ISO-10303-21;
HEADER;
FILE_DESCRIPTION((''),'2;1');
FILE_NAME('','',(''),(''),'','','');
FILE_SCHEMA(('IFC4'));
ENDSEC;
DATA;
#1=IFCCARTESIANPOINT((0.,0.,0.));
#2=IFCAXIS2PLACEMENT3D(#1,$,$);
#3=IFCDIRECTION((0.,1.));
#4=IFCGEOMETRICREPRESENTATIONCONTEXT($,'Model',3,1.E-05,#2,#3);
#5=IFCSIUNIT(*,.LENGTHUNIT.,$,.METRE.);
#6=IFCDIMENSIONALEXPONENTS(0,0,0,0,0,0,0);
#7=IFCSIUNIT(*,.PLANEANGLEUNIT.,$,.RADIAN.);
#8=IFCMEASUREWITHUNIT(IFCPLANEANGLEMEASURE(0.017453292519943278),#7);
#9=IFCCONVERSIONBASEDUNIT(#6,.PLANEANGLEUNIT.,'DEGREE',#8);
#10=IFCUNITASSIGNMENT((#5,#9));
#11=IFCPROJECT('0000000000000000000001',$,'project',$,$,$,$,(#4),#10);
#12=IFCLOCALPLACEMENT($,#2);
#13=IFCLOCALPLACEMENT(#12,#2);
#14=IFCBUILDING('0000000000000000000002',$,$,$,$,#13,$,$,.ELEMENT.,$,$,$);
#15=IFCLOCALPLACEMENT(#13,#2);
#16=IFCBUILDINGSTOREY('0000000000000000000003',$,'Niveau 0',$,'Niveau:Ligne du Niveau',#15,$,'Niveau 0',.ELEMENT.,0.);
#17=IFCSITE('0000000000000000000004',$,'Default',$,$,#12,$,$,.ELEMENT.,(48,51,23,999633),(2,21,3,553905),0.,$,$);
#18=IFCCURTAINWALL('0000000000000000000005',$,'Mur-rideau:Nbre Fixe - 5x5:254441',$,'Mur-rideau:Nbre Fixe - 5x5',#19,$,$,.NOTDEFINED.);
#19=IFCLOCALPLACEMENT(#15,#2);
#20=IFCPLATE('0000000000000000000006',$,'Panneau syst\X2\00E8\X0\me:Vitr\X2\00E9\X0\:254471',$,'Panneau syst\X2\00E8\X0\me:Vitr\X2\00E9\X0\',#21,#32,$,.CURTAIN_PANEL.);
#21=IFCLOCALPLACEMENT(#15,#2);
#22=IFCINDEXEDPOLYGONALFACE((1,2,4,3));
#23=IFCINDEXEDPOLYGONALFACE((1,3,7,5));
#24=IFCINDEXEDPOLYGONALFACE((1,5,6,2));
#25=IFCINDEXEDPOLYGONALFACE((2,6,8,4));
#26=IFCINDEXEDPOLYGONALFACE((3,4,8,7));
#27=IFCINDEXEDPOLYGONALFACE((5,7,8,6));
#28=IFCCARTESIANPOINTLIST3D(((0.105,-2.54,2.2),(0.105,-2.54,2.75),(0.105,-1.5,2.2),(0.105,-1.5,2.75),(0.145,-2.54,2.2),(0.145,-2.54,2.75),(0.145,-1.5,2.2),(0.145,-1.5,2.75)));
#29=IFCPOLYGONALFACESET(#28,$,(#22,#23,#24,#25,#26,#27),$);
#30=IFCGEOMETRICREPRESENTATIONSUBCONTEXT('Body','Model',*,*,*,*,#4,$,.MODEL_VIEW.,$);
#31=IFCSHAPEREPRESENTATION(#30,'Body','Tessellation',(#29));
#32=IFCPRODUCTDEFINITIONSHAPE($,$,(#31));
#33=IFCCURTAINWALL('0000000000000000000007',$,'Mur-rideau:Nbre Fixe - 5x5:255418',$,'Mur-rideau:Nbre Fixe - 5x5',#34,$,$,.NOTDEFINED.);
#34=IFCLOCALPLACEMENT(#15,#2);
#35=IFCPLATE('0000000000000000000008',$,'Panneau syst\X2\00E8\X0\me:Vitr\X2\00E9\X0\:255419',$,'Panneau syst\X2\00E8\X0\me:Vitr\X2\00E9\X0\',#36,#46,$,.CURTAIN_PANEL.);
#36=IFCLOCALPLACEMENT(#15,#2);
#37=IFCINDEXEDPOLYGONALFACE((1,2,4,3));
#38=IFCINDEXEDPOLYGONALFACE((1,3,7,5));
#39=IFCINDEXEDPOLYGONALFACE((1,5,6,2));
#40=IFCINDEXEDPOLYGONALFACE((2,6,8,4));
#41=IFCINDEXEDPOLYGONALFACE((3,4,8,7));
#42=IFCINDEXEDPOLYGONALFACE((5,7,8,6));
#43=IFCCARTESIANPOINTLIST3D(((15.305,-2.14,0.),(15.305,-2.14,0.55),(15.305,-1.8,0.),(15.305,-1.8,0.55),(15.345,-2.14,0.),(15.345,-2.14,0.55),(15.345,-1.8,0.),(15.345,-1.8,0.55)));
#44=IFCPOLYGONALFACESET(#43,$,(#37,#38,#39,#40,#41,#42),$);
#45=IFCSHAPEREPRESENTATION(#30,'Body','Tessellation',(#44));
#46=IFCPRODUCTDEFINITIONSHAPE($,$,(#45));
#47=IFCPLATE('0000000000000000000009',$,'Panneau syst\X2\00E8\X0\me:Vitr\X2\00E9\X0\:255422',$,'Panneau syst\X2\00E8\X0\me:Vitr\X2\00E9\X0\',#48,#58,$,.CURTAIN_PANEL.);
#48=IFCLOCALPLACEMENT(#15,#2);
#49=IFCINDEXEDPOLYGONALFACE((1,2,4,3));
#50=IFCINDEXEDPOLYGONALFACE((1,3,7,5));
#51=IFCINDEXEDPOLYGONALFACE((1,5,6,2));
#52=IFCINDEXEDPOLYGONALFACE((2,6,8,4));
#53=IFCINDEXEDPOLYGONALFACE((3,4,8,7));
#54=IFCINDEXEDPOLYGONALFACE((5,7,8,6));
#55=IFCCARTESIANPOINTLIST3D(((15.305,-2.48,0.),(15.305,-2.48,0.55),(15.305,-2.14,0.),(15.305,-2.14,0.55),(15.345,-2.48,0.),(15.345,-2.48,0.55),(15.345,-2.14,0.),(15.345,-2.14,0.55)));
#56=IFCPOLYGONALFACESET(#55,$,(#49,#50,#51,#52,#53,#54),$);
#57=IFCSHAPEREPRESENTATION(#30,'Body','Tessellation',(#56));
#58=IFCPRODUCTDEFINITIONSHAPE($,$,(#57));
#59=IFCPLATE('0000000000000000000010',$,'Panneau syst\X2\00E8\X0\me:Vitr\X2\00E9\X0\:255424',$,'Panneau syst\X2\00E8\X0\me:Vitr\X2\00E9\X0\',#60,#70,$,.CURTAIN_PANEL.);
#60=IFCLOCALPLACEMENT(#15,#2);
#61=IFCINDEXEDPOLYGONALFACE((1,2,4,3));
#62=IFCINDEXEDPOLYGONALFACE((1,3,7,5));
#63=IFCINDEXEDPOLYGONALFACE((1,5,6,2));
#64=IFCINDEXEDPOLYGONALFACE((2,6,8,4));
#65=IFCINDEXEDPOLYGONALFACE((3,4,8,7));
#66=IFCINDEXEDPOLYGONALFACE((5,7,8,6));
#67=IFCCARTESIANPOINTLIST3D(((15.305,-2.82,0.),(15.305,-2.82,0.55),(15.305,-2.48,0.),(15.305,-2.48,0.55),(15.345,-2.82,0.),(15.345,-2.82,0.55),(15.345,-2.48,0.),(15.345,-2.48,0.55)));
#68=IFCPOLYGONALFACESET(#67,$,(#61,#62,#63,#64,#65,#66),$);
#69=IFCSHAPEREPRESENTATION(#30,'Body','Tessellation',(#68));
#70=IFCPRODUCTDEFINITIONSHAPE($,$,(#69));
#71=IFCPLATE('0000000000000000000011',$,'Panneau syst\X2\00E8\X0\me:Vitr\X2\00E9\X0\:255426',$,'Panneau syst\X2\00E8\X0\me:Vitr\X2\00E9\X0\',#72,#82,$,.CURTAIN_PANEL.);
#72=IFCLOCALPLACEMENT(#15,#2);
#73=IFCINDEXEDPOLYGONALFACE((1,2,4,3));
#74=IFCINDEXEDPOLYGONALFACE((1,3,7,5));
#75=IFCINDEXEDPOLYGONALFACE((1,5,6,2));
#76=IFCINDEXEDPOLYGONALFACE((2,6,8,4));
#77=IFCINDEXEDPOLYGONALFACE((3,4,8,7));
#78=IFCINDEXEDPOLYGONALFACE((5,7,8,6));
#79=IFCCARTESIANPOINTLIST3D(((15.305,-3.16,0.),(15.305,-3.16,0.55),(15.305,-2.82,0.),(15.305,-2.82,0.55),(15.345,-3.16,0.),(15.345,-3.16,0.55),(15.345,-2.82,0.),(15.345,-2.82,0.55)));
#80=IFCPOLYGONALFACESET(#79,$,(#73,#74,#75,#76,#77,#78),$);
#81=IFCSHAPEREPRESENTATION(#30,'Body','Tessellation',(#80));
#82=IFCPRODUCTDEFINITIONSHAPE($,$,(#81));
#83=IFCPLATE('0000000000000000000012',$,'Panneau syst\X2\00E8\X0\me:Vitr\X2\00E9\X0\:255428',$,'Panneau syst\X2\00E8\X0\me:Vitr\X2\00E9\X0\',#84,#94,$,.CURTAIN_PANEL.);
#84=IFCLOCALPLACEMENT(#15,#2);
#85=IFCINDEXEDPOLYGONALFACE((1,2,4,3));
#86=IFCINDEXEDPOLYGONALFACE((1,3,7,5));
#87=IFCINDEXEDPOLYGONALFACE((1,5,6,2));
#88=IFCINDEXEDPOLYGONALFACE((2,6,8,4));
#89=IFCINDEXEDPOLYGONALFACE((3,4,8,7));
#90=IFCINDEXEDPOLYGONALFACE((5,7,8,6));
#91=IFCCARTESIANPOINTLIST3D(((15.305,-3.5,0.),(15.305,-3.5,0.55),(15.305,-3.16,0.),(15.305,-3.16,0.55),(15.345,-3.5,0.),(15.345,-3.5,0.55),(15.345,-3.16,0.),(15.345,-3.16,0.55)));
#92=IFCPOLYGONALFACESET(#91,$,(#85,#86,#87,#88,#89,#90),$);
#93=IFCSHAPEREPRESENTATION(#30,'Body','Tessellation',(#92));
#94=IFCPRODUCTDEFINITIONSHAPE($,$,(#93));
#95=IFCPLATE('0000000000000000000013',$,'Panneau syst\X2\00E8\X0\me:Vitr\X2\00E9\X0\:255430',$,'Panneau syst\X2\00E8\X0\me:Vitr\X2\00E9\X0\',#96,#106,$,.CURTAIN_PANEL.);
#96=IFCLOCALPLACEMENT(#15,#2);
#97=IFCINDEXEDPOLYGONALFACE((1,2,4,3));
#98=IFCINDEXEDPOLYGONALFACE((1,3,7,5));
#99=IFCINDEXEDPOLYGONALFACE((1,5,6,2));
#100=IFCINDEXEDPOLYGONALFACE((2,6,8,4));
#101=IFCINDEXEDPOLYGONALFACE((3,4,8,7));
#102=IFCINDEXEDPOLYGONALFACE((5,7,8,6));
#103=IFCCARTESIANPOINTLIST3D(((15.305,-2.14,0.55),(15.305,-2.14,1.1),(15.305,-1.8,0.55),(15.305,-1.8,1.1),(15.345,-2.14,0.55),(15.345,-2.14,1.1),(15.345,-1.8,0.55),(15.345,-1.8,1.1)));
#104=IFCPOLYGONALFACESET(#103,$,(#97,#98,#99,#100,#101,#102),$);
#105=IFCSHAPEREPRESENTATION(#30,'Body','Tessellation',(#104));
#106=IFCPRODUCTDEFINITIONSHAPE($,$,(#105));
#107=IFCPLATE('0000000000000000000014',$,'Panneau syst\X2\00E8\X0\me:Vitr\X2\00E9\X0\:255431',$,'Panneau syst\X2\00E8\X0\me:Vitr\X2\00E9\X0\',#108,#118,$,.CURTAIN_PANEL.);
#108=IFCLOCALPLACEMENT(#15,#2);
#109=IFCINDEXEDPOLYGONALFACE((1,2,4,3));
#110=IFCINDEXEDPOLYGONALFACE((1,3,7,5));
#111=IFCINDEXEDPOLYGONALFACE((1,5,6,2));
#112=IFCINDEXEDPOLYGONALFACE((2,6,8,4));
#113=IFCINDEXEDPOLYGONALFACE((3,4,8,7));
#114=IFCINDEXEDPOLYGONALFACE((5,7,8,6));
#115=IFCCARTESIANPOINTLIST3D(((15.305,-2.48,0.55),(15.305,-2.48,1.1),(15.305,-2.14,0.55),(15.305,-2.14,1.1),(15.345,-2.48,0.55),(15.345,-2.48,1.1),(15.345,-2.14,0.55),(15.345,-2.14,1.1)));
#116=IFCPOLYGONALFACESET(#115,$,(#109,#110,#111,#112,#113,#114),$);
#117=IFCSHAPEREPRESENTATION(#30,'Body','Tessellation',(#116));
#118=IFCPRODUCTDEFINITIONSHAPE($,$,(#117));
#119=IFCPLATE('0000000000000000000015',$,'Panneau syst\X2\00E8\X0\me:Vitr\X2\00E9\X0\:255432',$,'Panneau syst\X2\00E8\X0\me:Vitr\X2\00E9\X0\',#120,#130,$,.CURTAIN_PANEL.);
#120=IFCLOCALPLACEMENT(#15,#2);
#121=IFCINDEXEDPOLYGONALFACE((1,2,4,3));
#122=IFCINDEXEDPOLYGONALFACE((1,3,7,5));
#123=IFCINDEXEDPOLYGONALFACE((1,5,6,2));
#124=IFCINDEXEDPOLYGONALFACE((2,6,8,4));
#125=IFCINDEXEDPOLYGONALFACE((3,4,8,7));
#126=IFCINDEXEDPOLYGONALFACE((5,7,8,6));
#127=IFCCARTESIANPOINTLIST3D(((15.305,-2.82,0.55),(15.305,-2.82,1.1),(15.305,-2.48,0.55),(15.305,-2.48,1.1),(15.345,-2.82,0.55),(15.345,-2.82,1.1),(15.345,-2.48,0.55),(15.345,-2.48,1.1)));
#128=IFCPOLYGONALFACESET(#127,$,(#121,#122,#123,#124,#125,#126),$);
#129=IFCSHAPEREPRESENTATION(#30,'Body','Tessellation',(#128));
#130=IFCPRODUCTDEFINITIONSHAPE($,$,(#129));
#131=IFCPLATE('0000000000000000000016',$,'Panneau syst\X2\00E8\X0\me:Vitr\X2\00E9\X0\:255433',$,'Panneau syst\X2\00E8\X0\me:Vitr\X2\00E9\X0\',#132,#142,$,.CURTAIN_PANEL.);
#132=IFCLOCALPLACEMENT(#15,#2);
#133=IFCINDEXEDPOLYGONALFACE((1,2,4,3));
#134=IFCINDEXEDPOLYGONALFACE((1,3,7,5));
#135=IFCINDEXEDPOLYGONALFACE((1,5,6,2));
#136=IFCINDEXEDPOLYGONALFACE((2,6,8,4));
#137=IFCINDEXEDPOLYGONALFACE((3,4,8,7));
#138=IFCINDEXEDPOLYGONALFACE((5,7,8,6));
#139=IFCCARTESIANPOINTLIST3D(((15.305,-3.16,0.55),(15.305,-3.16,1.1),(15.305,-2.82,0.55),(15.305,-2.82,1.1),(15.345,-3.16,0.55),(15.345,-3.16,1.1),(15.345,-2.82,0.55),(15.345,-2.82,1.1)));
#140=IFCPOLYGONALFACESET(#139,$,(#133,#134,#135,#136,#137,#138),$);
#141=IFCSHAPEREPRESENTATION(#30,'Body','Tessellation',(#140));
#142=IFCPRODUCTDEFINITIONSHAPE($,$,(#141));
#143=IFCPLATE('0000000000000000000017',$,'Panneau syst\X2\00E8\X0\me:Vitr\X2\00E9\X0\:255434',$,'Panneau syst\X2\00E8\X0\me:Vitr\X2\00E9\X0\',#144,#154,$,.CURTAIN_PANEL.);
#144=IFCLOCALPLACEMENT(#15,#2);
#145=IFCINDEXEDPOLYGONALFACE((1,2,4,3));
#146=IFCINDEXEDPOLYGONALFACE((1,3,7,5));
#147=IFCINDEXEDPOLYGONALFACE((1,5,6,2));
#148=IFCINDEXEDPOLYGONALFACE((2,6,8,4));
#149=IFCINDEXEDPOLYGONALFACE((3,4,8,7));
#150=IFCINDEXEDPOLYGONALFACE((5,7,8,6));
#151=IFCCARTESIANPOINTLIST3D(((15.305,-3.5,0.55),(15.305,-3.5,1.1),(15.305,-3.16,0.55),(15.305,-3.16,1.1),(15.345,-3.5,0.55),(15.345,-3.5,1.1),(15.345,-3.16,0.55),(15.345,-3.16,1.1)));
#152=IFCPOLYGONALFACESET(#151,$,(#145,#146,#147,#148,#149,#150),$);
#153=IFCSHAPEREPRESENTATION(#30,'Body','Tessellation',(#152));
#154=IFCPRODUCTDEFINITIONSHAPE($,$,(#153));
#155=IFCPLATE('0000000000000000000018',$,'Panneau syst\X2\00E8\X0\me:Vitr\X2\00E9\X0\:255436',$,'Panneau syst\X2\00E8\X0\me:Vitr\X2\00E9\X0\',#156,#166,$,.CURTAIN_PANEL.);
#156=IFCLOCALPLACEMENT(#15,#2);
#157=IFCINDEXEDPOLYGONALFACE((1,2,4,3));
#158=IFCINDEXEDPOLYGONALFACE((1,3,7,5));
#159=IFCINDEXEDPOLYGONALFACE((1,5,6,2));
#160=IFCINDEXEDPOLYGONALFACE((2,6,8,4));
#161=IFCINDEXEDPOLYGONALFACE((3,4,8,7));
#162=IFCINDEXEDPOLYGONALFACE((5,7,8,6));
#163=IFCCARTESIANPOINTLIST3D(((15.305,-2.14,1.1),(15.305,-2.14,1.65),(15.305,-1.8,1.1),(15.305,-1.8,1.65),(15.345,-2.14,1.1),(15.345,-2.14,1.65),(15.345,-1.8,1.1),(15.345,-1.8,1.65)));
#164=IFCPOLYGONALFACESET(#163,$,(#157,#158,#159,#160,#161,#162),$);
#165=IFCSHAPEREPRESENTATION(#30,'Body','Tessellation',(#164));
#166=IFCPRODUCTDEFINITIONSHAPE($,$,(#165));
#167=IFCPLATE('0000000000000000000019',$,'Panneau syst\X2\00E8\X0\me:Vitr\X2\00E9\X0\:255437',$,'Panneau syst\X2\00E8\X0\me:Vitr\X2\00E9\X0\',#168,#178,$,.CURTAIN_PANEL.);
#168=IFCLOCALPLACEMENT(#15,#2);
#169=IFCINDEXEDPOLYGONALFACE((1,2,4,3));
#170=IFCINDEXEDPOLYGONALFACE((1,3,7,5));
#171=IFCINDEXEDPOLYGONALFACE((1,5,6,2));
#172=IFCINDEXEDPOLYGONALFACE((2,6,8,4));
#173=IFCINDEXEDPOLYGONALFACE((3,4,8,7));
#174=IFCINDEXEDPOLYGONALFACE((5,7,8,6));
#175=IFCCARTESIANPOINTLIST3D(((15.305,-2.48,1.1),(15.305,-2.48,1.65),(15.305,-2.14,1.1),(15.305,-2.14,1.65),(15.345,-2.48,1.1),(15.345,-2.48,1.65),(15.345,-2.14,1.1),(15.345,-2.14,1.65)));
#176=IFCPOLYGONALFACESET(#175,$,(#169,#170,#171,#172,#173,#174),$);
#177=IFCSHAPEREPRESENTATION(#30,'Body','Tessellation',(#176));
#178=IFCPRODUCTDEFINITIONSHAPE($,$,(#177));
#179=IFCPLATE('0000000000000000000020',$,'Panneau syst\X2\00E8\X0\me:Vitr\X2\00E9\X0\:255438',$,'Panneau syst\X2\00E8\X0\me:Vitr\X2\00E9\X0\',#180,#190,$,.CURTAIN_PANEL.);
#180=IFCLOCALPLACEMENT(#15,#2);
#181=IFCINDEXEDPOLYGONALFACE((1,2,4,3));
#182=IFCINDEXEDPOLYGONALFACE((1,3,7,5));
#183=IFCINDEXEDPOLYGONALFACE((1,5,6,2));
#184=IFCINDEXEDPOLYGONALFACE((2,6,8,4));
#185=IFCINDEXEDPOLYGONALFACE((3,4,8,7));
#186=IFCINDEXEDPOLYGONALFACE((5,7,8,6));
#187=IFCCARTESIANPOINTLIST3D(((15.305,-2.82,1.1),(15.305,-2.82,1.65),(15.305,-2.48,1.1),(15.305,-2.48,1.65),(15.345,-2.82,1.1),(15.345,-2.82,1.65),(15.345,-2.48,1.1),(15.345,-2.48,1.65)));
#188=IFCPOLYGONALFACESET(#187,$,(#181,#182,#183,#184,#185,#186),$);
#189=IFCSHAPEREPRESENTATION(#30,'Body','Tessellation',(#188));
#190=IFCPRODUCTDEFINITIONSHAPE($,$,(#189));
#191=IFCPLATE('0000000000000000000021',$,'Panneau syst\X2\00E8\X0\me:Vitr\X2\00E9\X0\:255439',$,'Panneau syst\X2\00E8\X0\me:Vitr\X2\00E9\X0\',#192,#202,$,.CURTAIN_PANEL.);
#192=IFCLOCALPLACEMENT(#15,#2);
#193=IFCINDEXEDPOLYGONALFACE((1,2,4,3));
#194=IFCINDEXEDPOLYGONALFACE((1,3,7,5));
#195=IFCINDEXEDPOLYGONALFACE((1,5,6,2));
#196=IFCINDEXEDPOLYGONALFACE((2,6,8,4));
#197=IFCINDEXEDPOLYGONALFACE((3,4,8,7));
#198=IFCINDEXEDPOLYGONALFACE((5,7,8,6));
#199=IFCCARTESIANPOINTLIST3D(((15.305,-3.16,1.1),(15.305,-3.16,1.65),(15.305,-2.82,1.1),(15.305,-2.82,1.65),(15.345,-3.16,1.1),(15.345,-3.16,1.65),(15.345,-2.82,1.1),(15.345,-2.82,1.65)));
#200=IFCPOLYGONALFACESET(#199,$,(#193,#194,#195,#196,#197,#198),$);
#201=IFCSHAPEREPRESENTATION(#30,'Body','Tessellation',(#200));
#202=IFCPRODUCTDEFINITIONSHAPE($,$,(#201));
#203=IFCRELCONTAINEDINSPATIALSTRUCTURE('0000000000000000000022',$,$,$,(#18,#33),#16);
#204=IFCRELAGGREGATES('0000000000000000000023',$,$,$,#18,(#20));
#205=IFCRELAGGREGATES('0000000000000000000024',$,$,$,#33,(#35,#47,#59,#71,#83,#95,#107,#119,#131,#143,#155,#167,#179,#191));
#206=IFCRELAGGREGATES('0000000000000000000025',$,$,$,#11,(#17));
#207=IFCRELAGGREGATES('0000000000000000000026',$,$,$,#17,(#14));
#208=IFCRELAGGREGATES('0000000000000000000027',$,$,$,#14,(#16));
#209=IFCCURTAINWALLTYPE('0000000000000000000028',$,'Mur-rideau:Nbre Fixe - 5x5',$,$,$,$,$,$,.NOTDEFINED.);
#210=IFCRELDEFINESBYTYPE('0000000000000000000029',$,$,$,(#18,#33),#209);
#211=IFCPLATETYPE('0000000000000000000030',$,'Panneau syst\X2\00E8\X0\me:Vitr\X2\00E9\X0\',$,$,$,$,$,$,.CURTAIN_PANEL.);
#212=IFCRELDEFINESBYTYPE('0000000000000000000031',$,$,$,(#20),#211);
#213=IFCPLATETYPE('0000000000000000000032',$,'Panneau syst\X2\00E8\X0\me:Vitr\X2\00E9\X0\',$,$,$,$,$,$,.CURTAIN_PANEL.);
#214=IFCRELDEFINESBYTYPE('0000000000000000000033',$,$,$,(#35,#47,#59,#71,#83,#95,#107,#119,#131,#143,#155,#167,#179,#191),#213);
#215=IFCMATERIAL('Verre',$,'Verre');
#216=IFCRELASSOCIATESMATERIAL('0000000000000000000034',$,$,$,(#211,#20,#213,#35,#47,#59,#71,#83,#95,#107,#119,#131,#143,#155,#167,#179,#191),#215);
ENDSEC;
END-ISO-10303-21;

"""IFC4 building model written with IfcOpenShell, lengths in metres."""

from ifc_helpers import new_model, entity, si_unit, converted_unit, direction, frame, origin, place, context, subcontext, project, spatial, indexed_curve, outline, extrude, source, transform, mapped, material, type_object, type_shapes, element, aggregate, save


model = new_model("IFC4")

# Units and contexts
model_context = context("Model", 3, precision=1e-05, world=origin(), true_north=direction((0.0, 1.0)))
body_context = subcontext(model_context, "Body", "Model", "MODEL_VIEW")
ifc_project = project(units=[si_unit("LENGTHUNIT", "METRE"), converted_unit("PLANEANGLEUNIT", "DEGREE", entity("IfcPlaneAngleMeasure", 0.017453292519943278), si_unit("PLANEANGLEUNIT", "RADIAN"), dimensions=[0, 0, 0, 0, 0, 0, 0])], contexts=[model_context])

# Site, building, storey
site_placement = place(None, origin())
site = spatial("IfcSite", under=ifc_project, at=site_placement, Name="Default", CompositionType="ELEMENT", RefLatitude=(48, 51, 23, 999633), RefLongitude=(2, 21, 3, 553905), RefElevation=0.0)
building_placement = place(site_placement, origin())
building = spatial("IfcBuilding", under=site, at=building_placement, CompositionType="ELEMENT")
storey_placement = place(building_placement, origin())
storey = spatial("IfcBuildingStorey", under=building, at=storey_placement, Name="Niveau 0", ObjectType="Niveau:Ligne du Niveau", LongName="Niveau 0", CompositionType="ELEMENT", Elevation=0.0)

# Curtain wall, plate
curtain_wall_type = type_object("IfcCurtainWallType", Name="Mur-rideau:Nbre Fixe - 5x5", PredefinedType="NOTDEFINED")
curtain_wall_1_placement = place(storey_placement, origin())
curtain_wall_1 = element("IfcCurtainWall", 1, at=curtain_wall_1_placement, inside=storey, type_object=curtain_wall_type, Name="Mur-rideau:Nbre Fixe - 5x5:254441", ObjectType="Mur-rideau:Nbre Fixe - 5x5", PredefinedType="NOTDEFINED")
ifc_material = material(Name="Verre", Category="Verre")
plate_type_1 = type_object("IfcPlateType", Name="Panneau système:Vitré", PredefinedType="CURTAIN_PANEL", material=ifc_material)
shared_shape_1 = source(origin(), body_context, "Body", "SweptSolid", [
    extrude(outline(indexed_curve([(-0.02, -0.52), (0.02, -0.52), (0.02, 0.52), (-0.02, 0.52), (-0.02, -0.52)], self_intersect=False)), frame((0.52, 0.02, 0.0), z_axis=(0.0, 0.0, 1.0), x_axis=(0.0, 1.0, 0.0)), (0.0, 0.0, 1.0), 0.55),
])
type_shapes(plate_type_1, [shared_shape_1])
plate_1_placement = place(curtain_wall_1_placement, frame((0.105, -1.5, 2.2), z_axis=(0.0, 0.0, 1.0), x_axis=(0.0, -1.0, 0.0)))
plate_1 = element("IfcPlate", 2, at=plate_1_placement, type_object=plate_type_1, material=ifc_material, Name="Panneau système:Vitré:254471", ObjectType="Panneau système:Vitré", PredefinedType="CURTAIN_PANEL", context=body_context, shape_type="MappedRepresentation", body=[
    mapped(shared_shape_1, transform((0.0, 0.0, 0.0), scale=1.0)),
])
aggregate(curtain_wall_1, [plate_1])

# Curtain wall, plates
curtain_wall_2_placement = place(storey_placement, origin())
curtain_wall_2 = element("IfcCurtainWall", 3, at=curtain_wall_2_placement, inside=storey, type_object=curtain_wall_type, Name="Mur-rideau:Nbre Fixe - 5x5:255418", ObjectType="Mur-rideau:Nbre Fixe - 5x5", PredefinedType="NOTDEFINED")
plate_type_2 = type_object("IfcPlateType", Name="Panneau système:Vitré", PredefinedType="CURTAIN_PANEL", material=ifc_material)
shared_shape_2 = source(origin(), body_context, "Body", "SweptSolid", [
    extrude(outline(indexed_curve([(-0.02, -0.17), (0.02, -0.17), (0.02, 0.17), (-0.02, 0.17), (-0.02, -0.17)], self_intersect=False)), frame((0.17, 0.02, 0.0), z_axis=(0.0, 0.0, 1.0), x_axis=(0.0, 1.0, 0.0)), (0.0, 0.0, 1.0), 0.55),
])
type_shapes(plate_type_2, [shared_shape_2])
plate_2_placement = place(curtain_wall_2_placement, frame((15.305, -1.8, 0.0), z_axis=(0.0, 0.0, 1.0), x_axis=(0.0, -1.0, 0.0)))
plate_2 = element("IfcPlate", 4, at=plate_2_placement, type_object=plate_type_2, material=ifc_material, Name="Panneau système:Vitré:255419", ObjectType="Panneau système:Vitré", PredefinedType="CURTAIN_PANEL", context=body_context, shape_type="MappedRepresentation", body=[
    mapped(shared_shape_2, transform((0.0, 0.0, 0.0), scale=1.0)),
])
plate_3_placement = place(curtain_wall_2_placement, frame((15.305, -2.14, 0.0), z_axis=(0.0, 0.0, 1.0), x_axis=(0.0, -1.0, 0.0)))
plate_3 = element("IfcPlate", 5, at=plate_3_placement, type_object=plate_type_2, material=ifc_material, Name="Panneau système:Vitré:255422", ObjectType="Panneau système:Vitré", PredefinedType="CURTAIN_PANEL", context=body_context, shape_type="MappedRepresentation", body=[
    mapped(shared_shape_2, transform((0.0, 0.0, 0.0), scale=1.0)),
])
plate_4_placement = place(curtain_wall_2_placement, frame((15.305, -2.48, 0.0), z_axis=(0.0, 0.0, 1.0), x_axis=(0.0, -1.0, 0.0)))
plate_4 = element("IfcPlate", 6, at=plate_4_placement, type_object=plate_type_2, material=ifc_material, Name="Panneau système:Vitré:255424", ObjectType="Panneau système:Vitré", PredefinedType="CURTAIN_PANEL", context=body_context, shape_type="MappedRepresentation", body=[
    mapped(shared_shape_2, transform((0.0, 0.0, 0.0), scale=1.0)),
])
plate_5_placement = place(curtain_wall_2_placement, frame((15.305, -2.82, 0.0), z_axis=(0.0, 0.0, 1.0), x_axis=(0.0, -1.0, 0.0)))
plate_5 = element("IfcPlate", 7, at=plate_5_placement, type_object=plate_type_2, material=ifc_material, Name="Panneau système:Vitré:255426", ObjectType="Panneau système:Vitré", PredefinedType="CURTAIN_PANEL", context=body_context, shape_type="MappedRepresentation", body=[
    mapped(shared_shape_2, transform((0.0, 0.0, 0.0), scale=1.0)),
])
plate_6_placement = place(curtain_wall_2_placement, frame((15.305, -3.16, 0.0), z_axis=(0.0, 0.0, 1.0), x_axis=(0.0, -1.0, 0.0)))
plate_6 = element("IfcPlate", 8, at=plate_6_placement, type_object=plate_type_2, material=ifc_material, Name="Panneau système:Vitré:255428", ObjectType="Panneau système:Vitré", PredefinedType="CURTAIN_PANEL", context=body_context, shape_type="MappedRepresentation", body=[
    mapped(shared_shape_2, transform((0.0, 0.0, 0.0), scale=1.0)),
])
plate_7_placement = place(curtain_wall_2_placement, frame((15.305, -1.8, 0.55), z_axis=(0.0, 0.0, 1.0), x_axis=(0.0, -1.0, 0.0)))
plate_7 = element("IfcPlate", 9, at=plate_7_placement, type_object=plate_type_2, material=ifc_material, Name="Panneau système:Vitré:255430", ObjectType="Panneau système:Vitré", PredefinedType="CURTAIN_PANEL", context=body_context, shape_type="MappedRepresentation", body=[
    mapped(shared_shape_2, transform((0.0, 0.0, 0.0), scale=1.0)),
])
plate_8_placement = place(curtain_wall_2_placement, frame((15.305, -2.14, 0.55), z_axis=(0.0, 0.0, 1.0), x_axis=(0.0, -1.0, 0.0)))
plate_8 = element("IfcPlate", 10, at=plate_8_placement, type_object=plate_type_2, material=ifc_material, Name="Panneau système:Vitré:255431", ObjectType="Panneau système:Vitré", PredefinedType="CURTAIN_PANEL", context=body_context, shape_type="MappedRepresentation", body=[
    mapped(shared_shape_2, transform((0.0, 0.0, 0.0), scale=1.0)),
])
plate_9_placement = place(curtain_wall_2_placement, frame((15.305, -2.48, 0.55), z_axis=(0.0, 0.0, 1.0), x_axis=(0.0, -1.0, 0.0)))
plate_9 = element("IfcPlate", 11, at=plate_9_placement, type_object=plate_type_2, material=ifc_material, Name="Panneau système:Vitré:255432", ObjectType="Panneau système:Vitré", PredefinedType="CURTAIN_PANEL", context=body_context, shape_type="MappedRepresentation", body=[
    mapped(shared_shape_2, transform((0.0, 0.0, 0.0), scale=1.0)),
])
plate_10_placement = place(curtain_wall_2_placement, frame((15.305, -2.82, 0.55), z_axis=(0.0, 0.0, 1.0), x_axis=(0.0, -1.0, 0.0)))
plate_10 = element("IfcPlate", 12, at=plate_10_placement, type_object=plate_type_2, material=ifc_material, Name="Panneau système:Vitré:255433", ObjectType="Panneau système:Vitré", PredefinedType="CURTAIN_PANEL", context=body_context, shape_type="MappedRepresentation", body=[
    mapped(shared_shape_2, transform((0.0, 0.0, 0.0), scale=1.0)),
])
plate_11_placement = place(curtain_wall_2_placement, frame((15.305, -3.16, 0.55), z_axis=(0.0, 0.0, 1.0), x_axis=(0.0, -1.0, 0.0)))
plate_11 = element("IfcPlate", 13, at=plate_11_placement, type_object=plate_type_2, material=ifc_material, Name="Panneau système:Vitré:255434", ObjectType="Panneau système:Vitré", PredefinedType="CURTAIN_PANEL", context=body_context, shape_type="MappedRepresentation", body=[
    mapped(shared_shape_2, transform((0.0, 0.0, 0.0), scale=1.0)),
])
plate_12_placement = place(curtain_wall_2_placement, frame((15.305, -1.8, 1.1), z_axis=(0.0, 0.0, 1.0), x_axis=(0.0, -1.0, 0.0)))
plate_12 = element("IfcPlate", 14, at=plate_12_placement, type_object=plate_type_2, material=ifc_material, Name="Panneau système:Vitré:255436", ObjectType="Panneau système:Vitré", PredefinedType="CURTAIN_PANEL", context=body_context, shape_type="MappedRepresentation", body=[
    mapped(shared_shape_2, transform((0.0, 0.0, 0.0), scale=1.0)),
])
plate_13_placement = place(curtain_wall_2_placement, frame((15.305, -2.14, 1.1), z_axis=(0.0, 0.0, 1.0), x_axis=(0.0, -1.0, 0.0)))
plate_13 = element("IfcPlate", 15, at=plate_13_placement, type_object=plate_type_2, material=ifc_material, Name="Panneau système:Vitré:255437", ObjectType="Panneau système:Vitré", PredefinedType="CURTAIN_PANEL", context=body_context, shape_type="MappedRepresentation", body=[
    mapped(shared_shape_2, transform((0.0, 0.0, 0.0), scale=1.0)),
])
plate_14_placement = place(curtain_wall_2_placement, frame((15.305, -2.48, 1.1), z_axis=(0.0, 0.0, 1.0), x_axis=(0.0, -1.0, 0.0)))
plate_14 = element("IfcPlate", 16, at=plate_14_placement, type_object=plate_type_2, material=ifc_material, Name="Panneau système:Vitré:255438", ObjectType="Panneau système:Vitré", PredefinedType="CURTAIN_PANEL", context=body_context, shape_type="MappedRepresentation", body=[
    mapped(shared_shape_2, transform((0.0, 0.0, 0.0), scale=1.0)),
])
plate_15_placement = place(curtain_wall_2_placement, frame((15.305, -2.82, 1.1), z_axis=(0.0, 0.0, 1.0), x_axis=(0.0, -1.0, 0.0)))
plate_15 = element("IfcPlate", 17, at=plate_15_placement, type_object=plate_type_2, material=ifc_material, Name="Panneau système:Vitré:255439", ObjectType="Panneau système:Vitré", PredefinedType="CURTAIN_PANEL", context=body_context, shape_type="MappedRepresentation", body=[
    mapped(shared_shape_2, transform((0.0, 0.0, 0.0), scale=1.0)),
])
aggregate(curtain_wall_2, [plate_2, plate_3, plate_4, plate_5, plate_6, plate_7, plate_8, plate_9, plate_10, plate_11, plate_12, plate_13, plate_14, plate_15])

save(model, "model.ifc")
